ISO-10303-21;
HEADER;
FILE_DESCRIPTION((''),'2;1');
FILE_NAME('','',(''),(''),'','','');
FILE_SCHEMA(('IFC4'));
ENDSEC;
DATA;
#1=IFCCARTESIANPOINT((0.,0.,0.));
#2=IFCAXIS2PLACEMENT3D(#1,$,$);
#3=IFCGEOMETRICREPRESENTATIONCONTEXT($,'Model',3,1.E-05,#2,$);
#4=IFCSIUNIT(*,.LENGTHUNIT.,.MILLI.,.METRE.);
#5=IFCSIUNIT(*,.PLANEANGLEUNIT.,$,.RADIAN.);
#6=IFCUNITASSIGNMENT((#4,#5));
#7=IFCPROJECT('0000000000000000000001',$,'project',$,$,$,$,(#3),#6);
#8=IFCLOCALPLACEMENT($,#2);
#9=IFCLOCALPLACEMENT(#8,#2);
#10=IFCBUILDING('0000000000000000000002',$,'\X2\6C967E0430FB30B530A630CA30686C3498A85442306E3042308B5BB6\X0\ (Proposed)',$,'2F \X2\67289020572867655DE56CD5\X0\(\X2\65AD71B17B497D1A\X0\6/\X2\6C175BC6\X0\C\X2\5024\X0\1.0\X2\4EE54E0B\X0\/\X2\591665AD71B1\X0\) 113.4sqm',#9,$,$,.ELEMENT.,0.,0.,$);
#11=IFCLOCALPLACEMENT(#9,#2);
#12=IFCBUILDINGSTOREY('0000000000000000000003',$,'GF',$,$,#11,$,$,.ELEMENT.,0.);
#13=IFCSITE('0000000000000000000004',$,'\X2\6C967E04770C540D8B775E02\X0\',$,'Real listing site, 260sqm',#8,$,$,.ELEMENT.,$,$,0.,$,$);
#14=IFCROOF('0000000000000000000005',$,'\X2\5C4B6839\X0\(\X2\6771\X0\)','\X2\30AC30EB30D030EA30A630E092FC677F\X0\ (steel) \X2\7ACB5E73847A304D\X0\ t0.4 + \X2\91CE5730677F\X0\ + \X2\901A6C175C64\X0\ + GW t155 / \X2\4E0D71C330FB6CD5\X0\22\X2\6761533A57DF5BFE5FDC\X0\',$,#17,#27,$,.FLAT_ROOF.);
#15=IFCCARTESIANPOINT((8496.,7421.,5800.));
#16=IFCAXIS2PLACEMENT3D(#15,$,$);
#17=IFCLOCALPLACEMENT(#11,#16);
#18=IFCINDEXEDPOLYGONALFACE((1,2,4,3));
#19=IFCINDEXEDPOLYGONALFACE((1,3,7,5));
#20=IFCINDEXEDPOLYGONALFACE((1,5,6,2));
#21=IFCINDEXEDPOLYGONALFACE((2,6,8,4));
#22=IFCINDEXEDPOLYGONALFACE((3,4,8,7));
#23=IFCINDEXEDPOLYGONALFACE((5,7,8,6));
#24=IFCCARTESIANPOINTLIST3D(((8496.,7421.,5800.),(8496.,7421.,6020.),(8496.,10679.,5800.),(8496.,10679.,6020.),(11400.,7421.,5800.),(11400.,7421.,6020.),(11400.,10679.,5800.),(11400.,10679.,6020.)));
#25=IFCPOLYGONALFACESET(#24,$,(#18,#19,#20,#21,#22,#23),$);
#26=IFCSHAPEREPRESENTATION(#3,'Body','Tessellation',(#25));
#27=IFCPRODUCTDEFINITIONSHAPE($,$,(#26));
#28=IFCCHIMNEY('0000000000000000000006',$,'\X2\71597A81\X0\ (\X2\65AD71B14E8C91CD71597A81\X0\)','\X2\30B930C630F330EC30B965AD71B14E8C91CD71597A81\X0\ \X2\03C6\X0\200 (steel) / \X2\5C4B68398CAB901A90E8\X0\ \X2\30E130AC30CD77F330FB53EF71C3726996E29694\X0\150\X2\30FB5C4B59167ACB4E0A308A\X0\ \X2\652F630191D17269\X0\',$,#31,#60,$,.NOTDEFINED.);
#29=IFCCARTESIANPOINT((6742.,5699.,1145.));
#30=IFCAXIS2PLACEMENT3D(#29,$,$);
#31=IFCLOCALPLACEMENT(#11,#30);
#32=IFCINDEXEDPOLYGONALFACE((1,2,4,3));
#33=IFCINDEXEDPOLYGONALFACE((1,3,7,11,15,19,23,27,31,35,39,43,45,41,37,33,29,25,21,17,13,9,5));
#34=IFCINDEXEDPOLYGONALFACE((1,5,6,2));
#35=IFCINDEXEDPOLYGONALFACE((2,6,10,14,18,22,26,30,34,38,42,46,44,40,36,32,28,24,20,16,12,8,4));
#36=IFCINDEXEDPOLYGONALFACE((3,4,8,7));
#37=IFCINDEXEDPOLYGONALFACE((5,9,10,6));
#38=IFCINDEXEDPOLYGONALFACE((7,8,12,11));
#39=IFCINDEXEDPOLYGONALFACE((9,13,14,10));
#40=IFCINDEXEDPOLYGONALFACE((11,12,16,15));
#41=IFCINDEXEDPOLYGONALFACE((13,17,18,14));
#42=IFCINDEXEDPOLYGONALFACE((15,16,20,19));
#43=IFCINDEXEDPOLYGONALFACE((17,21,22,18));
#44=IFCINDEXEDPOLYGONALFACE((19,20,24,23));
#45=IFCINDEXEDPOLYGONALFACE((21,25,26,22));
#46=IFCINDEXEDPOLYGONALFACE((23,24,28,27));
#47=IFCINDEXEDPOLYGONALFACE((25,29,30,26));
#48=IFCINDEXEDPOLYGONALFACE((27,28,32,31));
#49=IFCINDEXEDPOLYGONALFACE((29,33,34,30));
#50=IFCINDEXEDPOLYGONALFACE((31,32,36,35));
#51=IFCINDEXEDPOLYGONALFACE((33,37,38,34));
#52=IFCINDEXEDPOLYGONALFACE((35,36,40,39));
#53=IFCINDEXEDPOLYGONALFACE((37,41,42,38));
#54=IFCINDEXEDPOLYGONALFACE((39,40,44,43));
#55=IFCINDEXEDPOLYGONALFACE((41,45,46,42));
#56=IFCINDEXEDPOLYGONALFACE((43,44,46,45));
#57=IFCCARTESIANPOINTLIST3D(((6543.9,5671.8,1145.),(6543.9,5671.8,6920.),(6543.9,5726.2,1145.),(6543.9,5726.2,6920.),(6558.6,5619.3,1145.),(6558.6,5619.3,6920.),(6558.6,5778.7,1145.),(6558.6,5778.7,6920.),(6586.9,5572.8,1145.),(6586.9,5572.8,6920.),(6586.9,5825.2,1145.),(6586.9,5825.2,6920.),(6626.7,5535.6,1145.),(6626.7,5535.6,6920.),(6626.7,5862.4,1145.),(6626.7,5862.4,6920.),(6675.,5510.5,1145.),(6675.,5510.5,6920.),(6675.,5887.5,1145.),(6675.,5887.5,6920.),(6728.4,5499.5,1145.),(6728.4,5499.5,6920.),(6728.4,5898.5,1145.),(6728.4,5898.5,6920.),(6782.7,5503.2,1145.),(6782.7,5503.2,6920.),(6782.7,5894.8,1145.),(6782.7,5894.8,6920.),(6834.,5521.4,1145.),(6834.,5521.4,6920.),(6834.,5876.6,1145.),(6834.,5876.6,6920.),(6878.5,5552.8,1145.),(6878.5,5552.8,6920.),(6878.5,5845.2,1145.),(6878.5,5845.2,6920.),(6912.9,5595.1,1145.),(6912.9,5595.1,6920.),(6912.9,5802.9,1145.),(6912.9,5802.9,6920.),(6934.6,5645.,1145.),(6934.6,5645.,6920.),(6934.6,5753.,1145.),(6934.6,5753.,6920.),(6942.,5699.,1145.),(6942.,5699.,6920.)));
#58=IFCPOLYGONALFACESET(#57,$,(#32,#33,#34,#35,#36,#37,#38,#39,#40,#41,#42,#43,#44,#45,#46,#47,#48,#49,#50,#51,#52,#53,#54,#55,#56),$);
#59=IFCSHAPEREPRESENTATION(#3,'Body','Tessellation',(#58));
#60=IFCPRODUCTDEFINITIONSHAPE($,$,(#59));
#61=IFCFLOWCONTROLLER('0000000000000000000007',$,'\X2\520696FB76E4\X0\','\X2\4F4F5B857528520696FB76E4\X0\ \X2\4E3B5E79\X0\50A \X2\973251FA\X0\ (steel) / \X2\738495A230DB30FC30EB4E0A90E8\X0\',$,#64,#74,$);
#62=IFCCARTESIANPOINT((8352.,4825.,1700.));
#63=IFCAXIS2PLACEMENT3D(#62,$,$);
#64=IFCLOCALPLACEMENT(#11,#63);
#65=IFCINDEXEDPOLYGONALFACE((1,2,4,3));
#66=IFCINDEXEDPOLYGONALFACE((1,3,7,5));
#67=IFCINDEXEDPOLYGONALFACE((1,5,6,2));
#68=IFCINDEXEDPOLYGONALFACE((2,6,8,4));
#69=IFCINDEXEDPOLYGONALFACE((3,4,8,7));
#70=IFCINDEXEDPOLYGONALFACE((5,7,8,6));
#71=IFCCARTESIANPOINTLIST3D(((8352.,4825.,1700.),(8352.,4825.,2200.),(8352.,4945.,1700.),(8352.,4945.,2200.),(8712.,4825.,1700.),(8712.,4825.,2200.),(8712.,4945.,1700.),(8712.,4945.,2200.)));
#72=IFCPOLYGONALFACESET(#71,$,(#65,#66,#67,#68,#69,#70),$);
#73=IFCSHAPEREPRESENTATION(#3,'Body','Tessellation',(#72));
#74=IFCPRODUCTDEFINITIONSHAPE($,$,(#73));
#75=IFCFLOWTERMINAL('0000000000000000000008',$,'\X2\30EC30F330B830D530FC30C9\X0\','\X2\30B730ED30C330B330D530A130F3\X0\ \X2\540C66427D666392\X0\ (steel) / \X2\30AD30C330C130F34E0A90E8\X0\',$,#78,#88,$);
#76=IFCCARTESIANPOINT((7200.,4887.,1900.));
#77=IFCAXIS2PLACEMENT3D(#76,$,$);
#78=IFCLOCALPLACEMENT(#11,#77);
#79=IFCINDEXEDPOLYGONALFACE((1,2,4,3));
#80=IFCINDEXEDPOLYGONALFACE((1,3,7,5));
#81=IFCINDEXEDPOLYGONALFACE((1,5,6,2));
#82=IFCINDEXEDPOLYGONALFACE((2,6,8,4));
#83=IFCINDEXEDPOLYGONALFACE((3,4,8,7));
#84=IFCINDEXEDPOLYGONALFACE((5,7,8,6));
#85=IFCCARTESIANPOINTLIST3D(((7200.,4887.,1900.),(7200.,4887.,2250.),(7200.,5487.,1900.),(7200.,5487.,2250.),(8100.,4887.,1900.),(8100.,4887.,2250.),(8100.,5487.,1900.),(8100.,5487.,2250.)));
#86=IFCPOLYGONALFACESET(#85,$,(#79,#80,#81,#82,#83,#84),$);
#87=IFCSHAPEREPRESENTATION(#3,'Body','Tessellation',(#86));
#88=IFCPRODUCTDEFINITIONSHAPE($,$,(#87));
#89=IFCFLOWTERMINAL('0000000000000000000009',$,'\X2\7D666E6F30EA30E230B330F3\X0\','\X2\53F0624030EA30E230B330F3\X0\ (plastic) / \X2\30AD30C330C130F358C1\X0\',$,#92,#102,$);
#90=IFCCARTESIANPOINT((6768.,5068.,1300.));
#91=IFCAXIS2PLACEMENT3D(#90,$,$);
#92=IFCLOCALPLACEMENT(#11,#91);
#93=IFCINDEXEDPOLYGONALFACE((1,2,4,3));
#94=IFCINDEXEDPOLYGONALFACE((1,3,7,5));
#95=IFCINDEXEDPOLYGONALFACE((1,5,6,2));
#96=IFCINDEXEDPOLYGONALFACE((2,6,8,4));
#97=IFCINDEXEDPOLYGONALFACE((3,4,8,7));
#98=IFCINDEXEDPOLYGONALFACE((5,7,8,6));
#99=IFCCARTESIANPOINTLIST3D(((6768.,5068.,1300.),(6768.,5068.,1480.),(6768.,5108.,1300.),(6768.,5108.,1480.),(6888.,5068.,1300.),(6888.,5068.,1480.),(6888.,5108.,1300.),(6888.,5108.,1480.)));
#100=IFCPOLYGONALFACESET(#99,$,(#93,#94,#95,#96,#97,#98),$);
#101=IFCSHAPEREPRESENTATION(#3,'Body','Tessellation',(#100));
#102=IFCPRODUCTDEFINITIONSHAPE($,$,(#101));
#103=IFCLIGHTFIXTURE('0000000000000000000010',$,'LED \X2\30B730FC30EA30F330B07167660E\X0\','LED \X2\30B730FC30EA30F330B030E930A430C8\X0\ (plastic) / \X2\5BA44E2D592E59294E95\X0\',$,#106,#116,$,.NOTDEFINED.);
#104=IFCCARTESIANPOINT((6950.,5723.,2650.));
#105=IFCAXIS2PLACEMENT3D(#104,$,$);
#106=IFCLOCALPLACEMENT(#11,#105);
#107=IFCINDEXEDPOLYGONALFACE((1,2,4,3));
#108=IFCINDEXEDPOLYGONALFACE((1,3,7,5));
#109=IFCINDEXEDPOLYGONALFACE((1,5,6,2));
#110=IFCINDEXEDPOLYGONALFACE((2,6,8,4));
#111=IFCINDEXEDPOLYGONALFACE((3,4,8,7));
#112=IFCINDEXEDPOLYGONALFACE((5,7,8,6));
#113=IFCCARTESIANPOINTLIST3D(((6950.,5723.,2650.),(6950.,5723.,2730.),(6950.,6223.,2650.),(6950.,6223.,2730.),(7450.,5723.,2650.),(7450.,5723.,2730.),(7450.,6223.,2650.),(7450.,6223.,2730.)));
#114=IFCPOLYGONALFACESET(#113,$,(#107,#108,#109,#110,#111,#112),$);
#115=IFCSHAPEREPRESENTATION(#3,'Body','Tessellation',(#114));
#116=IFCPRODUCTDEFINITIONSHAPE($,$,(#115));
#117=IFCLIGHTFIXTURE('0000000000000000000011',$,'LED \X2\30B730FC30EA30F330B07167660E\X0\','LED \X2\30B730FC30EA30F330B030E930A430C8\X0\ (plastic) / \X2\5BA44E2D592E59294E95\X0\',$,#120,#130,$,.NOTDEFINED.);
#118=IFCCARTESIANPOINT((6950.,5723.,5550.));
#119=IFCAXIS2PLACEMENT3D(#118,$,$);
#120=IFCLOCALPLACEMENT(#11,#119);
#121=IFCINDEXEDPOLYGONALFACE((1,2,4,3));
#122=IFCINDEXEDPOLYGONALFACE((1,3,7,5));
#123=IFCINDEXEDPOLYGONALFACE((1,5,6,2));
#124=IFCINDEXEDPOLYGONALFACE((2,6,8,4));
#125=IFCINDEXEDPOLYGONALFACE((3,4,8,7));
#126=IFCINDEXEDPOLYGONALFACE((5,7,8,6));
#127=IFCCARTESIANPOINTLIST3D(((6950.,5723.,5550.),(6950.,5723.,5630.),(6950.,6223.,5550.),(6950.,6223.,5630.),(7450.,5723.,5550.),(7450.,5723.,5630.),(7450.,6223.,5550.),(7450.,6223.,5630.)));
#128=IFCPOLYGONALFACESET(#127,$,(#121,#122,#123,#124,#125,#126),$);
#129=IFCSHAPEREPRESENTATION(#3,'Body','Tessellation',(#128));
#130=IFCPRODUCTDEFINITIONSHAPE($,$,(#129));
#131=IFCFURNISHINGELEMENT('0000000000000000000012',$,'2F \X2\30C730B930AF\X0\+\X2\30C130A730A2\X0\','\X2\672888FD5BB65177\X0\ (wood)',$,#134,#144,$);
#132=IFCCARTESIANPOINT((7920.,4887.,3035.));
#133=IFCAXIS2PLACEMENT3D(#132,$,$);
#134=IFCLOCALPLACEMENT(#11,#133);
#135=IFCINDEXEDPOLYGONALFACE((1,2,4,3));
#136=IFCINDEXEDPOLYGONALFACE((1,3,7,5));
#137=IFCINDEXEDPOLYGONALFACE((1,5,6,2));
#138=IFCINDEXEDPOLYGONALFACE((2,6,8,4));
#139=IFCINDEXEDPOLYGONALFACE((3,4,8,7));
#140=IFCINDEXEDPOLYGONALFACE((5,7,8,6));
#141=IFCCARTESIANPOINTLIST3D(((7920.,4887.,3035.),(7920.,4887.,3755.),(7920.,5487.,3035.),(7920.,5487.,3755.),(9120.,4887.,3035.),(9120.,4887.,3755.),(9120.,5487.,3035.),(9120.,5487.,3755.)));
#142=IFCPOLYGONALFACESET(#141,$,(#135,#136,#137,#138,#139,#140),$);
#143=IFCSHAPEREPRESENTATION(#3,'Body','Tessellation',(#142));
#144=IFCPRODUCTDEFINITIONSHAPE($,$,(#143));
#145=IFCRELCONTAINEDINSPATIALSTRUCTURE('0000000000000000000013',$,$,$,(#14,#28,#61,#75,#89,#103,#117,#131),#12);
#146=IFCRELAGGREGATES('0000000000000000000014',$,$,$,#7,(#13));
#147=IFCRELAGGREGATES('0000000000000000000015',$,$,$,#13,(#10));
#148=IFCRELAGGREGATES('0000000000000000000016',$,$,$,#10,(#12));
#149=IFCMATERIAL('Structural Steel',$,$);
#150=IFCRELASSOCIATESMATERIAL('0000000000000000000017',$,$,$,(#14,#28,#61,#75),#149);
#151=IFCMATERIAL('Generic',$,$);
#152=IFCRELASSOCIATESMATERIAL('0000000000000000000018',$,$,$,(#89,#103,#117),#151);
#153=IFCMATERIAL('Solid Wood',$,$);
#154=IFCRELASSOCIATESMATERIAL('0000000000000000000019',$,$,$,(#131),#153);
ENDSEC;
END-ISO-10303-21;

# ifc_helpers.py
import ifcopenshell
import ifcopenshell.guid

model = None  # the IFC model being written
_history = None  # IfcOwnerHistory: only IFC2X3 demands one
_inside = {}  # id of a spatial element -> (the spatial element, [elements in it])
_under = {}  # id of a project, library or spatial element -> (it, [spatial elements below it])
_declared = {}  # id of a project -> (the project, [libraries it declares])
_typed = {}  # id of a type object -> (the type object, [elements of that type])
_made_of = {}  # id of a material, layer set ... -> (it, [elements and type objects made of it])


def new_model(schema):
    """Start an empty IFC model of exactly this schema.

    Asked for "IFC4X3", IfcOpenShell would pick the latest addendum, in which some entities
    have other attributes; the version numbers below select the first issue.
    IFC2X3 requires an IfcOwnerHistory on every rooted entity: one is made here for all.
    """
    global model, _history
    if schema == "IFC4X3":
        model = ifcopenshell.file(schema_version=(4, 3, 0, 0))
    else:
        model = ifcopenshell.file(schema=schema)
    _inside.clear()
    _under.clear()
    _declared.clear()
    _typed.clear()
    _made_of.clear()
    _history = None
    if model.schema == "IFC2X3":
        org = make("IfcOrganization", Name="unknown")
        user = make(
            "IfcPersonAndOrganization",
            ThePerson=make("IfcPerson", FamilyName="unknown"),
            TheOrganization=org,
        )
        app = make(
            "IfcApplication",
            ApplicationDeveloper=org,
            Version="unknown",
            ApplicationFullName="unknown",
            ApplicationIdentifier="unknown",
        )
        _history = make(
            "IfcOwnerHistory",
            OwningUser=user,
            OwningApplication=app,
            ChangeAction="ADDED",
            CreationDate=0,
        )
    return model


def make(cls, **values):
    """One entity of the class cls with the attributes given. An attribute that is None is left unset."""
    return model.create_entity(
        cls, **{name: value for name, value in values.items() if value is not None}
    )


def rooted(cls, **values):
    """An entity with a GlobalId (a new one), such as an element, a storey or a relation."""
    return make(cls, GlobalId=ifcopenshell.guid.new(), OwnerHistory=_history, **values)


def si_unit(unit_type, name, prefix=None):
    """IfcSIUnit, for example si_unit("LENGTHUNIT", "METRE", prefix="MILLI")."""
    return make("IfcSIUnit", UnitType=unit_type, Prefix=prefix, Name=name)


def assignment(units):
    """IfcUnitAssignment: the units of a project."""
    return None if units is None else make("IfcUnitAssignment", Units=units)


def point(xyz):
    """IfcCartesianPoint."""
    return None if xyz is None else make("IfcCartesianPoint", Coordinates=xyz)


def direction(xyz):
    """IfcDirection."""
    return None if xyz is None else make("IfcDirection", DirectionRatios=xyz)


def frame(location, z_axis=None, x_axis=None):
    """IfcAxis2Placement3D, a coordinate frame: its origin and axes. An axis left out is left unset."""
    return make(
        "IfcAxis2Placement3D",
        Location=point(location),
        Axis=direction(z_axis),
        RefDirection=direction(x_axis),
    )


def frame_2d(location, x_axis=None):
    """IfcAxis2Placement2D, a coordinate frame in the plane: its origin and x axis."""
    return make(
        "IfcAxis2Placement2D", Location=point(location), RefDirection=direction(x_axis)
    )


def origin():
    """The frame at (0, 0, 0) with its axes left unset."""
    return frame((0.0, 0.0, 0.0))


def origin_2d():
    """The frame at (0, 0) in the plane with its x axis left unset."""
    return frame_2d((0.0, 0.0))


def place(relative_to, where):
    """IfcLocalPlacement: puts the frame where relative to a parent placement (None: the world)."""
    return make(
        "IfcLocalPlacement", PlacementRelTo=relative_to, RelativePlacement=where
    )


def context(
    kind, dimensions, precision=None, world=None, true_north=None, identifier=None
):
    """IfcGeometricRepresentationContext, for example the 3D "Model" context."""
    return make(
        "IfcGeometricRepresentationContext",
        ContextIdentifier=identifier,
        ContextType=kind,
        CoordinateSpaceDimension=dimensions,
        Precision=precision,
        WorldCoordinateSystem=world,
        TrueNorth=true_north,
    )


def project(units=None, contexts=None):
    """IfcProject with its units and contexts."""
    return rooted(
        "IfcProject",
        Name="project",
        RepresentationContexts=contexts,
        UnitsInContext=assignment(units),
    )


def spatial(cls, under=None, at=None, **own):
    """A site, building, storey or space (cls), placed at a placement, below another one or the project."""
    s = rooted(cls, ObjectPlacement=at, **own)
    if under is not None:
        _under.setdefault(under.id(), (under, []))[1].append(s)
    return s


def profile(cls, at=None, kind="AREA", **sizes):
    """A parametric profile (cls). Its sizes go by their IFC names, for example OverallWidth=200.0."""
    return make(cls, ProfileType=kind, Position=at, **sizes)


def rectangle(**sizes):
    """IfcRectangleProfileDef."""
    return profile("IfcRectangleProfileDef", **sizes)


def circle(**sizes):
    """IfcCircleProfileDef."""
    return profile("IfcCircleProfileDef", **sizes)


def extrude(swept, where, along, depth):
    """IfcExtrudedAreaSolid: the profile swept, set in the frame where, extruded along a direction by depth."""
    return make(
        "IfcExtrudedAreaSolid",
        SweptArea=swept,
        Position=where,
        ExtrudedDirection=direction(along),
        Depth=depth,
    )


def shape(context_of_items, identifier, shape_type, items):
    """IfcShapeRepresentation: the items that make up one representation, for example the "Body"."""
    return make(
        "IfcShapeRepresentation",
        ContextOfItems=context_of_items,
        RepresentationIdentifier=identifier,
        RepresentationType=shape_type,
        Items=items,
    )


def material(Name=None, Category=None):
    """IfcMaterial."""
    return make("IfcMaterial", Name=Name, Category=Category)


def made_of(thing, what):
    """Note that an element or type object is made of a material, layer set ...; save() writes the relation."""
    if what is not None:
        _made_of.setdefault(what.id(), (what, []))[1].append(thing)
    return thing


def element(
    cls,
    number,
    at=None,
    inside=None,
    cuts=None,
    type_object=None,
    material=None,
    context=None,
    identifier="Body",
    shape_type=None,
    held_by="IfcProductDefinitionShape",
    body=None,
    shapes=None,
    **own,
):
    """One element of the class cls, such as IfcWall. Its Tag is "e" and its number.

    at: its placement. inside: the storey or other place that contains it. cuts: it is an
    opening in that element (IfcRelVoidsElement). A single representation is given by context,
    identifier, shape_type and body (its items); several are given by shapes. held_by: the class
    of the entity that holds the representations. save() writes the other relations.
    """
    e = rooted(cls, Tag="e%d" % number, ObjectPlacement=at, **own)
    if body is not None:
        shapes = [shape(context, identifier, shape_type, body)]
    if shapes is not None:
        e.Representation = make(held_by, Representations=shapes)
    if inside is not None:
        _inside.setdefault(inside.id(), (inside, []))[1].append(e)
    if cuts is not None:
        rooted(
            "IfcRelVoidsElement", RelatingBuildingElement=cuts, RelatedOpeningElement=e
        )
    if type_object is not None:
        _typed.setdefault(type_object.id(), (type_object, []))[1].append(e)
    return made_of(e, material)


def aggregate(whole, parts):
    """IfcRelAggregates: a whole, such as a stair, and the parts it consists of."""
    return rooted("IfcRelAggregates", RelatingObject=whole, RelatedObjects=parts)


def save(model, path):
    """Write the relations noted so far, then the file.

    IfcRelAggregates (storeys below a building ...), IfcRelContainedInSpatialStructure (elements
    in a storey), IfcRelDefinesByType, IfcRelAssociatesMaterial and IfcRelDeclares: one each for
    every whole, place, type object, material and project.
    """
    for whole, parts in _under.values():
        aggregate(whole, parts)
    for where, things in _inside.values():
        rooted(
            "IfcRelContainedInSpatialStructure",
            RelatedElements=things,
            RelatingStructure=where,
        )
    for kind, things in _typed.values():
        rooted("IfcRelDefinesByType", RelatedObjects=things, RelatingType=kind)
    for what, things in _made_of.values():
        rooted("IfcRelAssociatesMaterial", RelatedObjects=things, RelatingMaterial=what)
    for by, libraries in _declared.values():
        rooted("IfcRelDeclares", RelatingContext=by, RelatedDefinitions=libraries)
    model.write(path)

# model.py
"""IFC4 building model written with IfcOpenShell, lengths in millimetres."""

from ifc_helpers import new_model, si_unit, frame, frame_2d, origin, origin_2d, place, context, project, spatial, rectangle, circle, extrude, material, element, save


model = new_model("IFC4")

# Units and contexts
model_context = context("Model", 3, precision=1e-05, world=origin())
ifc_project = project(units=[si_unit("LENGTHUNIT", "METRE", prefix="MILLI"), si_unit("PLANEANGLEUNIT", "RADIAN")], contexts=[model_context])

# Site, building, storey
site_placement = place(None, origin())
site = spatial("IfcSite", under=ifc_project, at=site_placement, Name="沖縄県名護市", ObjectType="Real listing site, 260sqm", CompositionType="ELEMENT", RefElevation=0.0)
building_placement = place(site_placement, origin())
building = spatial("IfcBuilding", under=site, at=building_placement, Name="沖縄・サウナと水風呂のある家 (Proposed)", ObjectType="2F 木造在来工法(断熱等級6/気密C値1.0以下/外断熱) 113.4sqm", CompositionType="ELEMENT", ElevationOfRefHeight=0.0, ElevationOfTerrain=0.0)
storey_placement = place(building_placement, origin())
storey = spatial("IfcBuildingStorey", under=building, at=storey_placement, Name="GF", CompositionType="ELEMENT", Elevation=0.0)

# Shared definitions
ifc_material_1 = material(Name="Solid Wood")

# Roof
ifc_material_2 = material(Name="Structural Steel")
for number, where, name in (
    (1, (8496.0, 7421.0, 5800.0), "屋根(東)"),
):
    element("IfcRoof", number, at=place(storey_placement, frame(where)), inside=storey, material=ifc_material_2, Name=name, Description="ガルバリウム鋼板 (steel) 立平葺き t0.4 + 野地板 + 通気層 + GW t155 / 不燃・法22条区域対応", PredefinedType="FLAT_ROOF", context=model_context, shape_type="SweptSolid", body=[
        extrude(rectangle(XDim=2904.0, YDim=3258.0, at=frame_2d((1452.0, 1629.0))), frame((8496.0, 7421.0, 5800.0)), (0.0, 0.0, 1.0), 220.0),
    ])

# Chimney
chimney_placement = place(storey_placement, frame((6742.0, 5699.0, 1145.0)))
element("IfcChimney", 2, at=chimney_placement, inside=storey, material=ifc_material_2, Name="煙突 (断熱二重煙突)", Description="ステンレス断熱二重煙突 φ200 (steel) / 屋根貫通部 メガネ石・可燃物離隔150・屋外立上り 支持金物", PredefinedType="NOTDEFINED", context=model_context, shape_type="SweptSolid", body=[
    extrude(circle(Radius=200.0, at=origin_2d()), frame((6742.0, 5699.0, 1145.0)), (0.0, 0.0, 1.0), 5775.0),
])

# Flow controller
flow_controller_placement = place(storey_placement, frame((8352.0, 4825.0, 1700.0)))
element("IfcFlowController", 3, at=flow_controller_placement, inside=storey, material=ifc_material_2, Name="分電盤", Description="住宅用分電盤 主幹50A 露出 (steel) / 玄関ホール上部", context=model_context, shape_type="SweptSolid", body=[
    extrude(rectangle(XDim=360.0, YDim=120.0, at=frame_2d((180.0, 60.0))), frame((8352.0, 4825.0, 1700.0)), (0.0, 0.0, 1.0), 500.0),
])

# Flow terminals
flow_terminal_1_placement = place(storey_placement, frame((7200.0, 4887.0, 1900.0)))
element("IfcFlowTerminal", 4, at=flow_terminal_1_placement, inside=storey, material=ifc_material_2, Name="レンジフード", Description="シロッコファン 同時給排 (steel) / キッチン上部", context=model_context, shape_type="SweptSolid", body=[
    extrude(rectangle(XDim=900.0, YDim=600.0, at=frame_2d((450.0, 300.0))), frame((7200.0, 4887.0, 1900.0)), (0.0, 0.0, 1.0), 350.0),
])
ifc_material_3 = material(Name="Generic")
flow_terminal_2_placement = place(storey_placement, frame((6768.0, 5068.0, 1300.0)))
element("IfcFlowTerminal", 5, at=flow_terminal_2_placement, inside=storey, material=ifc_material_3, Name="給湯リモコン", Description="台所リモコン (plastic) / キッチン壁", context=model_context, shape_type="SweptSolid", body=[
    extrude(rectangle(XDim=120.0, YDim=40.0, at=frame_2d((60.0, 20.0))), frame((6768.0, 5068.0, 1300.0)), (0.0, 0.0, 1.0), 180.0),
])

# Light fixtures
light_fixture_1_placement = place(storey_placement, frame((6950.0, 5723.0, 2650.0)))
element("IfcLightFixture", 6, at=light_fixture_1_placement, inside=storey, material=ifc_material_3, Name="LED シーリング照明", Description="LED シーリングライト (plastic) / 室中央天井", PredefinedType="NOTDEFINED", context=model_context, shape_type="SweptSolid", body=[
    extrude(rectangle(XDim=500.0, YDim=500.0, at=frame_2d((250.0, 250.0))), frame((6950.0, 5723.0, 2650.0)), (0.0, 0.0, 1.0), 80.0),
])
light_fixture_2_placement = place(storey_placement, frame((6950.0, 5723.0, 5550.0)))
element("IfcLightFixture", 7, at=light_fixture_2_placement, inside=storey, material=ifc_material_3, Name="LED シーリング照明", Description="LED シーリングライト (plastic) / 室中央天井", PredefinedType="NOTDEFINED", context=model_context, shape_type="SweptSolid", body=[
    extrude(rectangle(XDim=500.0, YDim=500.0, at=frame_2d((250.0, 250.0))), frame((6950.0, 5723.0, 5550.0)), (0.0, 0.0, 1.0), 80.0),
])

# Furnishing element
furnishing_placement = place(storey_placement, frame((7920.0, 4887.0, 3035.0)))
element("IfcFurnishingElement", 8, at=furnishing_placement, inside=storey, material=ifc_material_1, Name="2F デスク+チェア", Description="木製家具 (wood)", context=model_context, shape_type="SweptSolid", body=[
    extrude(rectangle(XDim=1200.0, YDim=600.0, at=frame_2d((600.0, 300.0))), frame((7920.0, 4887.0, 3035.0)), (0.0, 0.0, 1.0), 720.0),
])

save(model, "model.ifc")
